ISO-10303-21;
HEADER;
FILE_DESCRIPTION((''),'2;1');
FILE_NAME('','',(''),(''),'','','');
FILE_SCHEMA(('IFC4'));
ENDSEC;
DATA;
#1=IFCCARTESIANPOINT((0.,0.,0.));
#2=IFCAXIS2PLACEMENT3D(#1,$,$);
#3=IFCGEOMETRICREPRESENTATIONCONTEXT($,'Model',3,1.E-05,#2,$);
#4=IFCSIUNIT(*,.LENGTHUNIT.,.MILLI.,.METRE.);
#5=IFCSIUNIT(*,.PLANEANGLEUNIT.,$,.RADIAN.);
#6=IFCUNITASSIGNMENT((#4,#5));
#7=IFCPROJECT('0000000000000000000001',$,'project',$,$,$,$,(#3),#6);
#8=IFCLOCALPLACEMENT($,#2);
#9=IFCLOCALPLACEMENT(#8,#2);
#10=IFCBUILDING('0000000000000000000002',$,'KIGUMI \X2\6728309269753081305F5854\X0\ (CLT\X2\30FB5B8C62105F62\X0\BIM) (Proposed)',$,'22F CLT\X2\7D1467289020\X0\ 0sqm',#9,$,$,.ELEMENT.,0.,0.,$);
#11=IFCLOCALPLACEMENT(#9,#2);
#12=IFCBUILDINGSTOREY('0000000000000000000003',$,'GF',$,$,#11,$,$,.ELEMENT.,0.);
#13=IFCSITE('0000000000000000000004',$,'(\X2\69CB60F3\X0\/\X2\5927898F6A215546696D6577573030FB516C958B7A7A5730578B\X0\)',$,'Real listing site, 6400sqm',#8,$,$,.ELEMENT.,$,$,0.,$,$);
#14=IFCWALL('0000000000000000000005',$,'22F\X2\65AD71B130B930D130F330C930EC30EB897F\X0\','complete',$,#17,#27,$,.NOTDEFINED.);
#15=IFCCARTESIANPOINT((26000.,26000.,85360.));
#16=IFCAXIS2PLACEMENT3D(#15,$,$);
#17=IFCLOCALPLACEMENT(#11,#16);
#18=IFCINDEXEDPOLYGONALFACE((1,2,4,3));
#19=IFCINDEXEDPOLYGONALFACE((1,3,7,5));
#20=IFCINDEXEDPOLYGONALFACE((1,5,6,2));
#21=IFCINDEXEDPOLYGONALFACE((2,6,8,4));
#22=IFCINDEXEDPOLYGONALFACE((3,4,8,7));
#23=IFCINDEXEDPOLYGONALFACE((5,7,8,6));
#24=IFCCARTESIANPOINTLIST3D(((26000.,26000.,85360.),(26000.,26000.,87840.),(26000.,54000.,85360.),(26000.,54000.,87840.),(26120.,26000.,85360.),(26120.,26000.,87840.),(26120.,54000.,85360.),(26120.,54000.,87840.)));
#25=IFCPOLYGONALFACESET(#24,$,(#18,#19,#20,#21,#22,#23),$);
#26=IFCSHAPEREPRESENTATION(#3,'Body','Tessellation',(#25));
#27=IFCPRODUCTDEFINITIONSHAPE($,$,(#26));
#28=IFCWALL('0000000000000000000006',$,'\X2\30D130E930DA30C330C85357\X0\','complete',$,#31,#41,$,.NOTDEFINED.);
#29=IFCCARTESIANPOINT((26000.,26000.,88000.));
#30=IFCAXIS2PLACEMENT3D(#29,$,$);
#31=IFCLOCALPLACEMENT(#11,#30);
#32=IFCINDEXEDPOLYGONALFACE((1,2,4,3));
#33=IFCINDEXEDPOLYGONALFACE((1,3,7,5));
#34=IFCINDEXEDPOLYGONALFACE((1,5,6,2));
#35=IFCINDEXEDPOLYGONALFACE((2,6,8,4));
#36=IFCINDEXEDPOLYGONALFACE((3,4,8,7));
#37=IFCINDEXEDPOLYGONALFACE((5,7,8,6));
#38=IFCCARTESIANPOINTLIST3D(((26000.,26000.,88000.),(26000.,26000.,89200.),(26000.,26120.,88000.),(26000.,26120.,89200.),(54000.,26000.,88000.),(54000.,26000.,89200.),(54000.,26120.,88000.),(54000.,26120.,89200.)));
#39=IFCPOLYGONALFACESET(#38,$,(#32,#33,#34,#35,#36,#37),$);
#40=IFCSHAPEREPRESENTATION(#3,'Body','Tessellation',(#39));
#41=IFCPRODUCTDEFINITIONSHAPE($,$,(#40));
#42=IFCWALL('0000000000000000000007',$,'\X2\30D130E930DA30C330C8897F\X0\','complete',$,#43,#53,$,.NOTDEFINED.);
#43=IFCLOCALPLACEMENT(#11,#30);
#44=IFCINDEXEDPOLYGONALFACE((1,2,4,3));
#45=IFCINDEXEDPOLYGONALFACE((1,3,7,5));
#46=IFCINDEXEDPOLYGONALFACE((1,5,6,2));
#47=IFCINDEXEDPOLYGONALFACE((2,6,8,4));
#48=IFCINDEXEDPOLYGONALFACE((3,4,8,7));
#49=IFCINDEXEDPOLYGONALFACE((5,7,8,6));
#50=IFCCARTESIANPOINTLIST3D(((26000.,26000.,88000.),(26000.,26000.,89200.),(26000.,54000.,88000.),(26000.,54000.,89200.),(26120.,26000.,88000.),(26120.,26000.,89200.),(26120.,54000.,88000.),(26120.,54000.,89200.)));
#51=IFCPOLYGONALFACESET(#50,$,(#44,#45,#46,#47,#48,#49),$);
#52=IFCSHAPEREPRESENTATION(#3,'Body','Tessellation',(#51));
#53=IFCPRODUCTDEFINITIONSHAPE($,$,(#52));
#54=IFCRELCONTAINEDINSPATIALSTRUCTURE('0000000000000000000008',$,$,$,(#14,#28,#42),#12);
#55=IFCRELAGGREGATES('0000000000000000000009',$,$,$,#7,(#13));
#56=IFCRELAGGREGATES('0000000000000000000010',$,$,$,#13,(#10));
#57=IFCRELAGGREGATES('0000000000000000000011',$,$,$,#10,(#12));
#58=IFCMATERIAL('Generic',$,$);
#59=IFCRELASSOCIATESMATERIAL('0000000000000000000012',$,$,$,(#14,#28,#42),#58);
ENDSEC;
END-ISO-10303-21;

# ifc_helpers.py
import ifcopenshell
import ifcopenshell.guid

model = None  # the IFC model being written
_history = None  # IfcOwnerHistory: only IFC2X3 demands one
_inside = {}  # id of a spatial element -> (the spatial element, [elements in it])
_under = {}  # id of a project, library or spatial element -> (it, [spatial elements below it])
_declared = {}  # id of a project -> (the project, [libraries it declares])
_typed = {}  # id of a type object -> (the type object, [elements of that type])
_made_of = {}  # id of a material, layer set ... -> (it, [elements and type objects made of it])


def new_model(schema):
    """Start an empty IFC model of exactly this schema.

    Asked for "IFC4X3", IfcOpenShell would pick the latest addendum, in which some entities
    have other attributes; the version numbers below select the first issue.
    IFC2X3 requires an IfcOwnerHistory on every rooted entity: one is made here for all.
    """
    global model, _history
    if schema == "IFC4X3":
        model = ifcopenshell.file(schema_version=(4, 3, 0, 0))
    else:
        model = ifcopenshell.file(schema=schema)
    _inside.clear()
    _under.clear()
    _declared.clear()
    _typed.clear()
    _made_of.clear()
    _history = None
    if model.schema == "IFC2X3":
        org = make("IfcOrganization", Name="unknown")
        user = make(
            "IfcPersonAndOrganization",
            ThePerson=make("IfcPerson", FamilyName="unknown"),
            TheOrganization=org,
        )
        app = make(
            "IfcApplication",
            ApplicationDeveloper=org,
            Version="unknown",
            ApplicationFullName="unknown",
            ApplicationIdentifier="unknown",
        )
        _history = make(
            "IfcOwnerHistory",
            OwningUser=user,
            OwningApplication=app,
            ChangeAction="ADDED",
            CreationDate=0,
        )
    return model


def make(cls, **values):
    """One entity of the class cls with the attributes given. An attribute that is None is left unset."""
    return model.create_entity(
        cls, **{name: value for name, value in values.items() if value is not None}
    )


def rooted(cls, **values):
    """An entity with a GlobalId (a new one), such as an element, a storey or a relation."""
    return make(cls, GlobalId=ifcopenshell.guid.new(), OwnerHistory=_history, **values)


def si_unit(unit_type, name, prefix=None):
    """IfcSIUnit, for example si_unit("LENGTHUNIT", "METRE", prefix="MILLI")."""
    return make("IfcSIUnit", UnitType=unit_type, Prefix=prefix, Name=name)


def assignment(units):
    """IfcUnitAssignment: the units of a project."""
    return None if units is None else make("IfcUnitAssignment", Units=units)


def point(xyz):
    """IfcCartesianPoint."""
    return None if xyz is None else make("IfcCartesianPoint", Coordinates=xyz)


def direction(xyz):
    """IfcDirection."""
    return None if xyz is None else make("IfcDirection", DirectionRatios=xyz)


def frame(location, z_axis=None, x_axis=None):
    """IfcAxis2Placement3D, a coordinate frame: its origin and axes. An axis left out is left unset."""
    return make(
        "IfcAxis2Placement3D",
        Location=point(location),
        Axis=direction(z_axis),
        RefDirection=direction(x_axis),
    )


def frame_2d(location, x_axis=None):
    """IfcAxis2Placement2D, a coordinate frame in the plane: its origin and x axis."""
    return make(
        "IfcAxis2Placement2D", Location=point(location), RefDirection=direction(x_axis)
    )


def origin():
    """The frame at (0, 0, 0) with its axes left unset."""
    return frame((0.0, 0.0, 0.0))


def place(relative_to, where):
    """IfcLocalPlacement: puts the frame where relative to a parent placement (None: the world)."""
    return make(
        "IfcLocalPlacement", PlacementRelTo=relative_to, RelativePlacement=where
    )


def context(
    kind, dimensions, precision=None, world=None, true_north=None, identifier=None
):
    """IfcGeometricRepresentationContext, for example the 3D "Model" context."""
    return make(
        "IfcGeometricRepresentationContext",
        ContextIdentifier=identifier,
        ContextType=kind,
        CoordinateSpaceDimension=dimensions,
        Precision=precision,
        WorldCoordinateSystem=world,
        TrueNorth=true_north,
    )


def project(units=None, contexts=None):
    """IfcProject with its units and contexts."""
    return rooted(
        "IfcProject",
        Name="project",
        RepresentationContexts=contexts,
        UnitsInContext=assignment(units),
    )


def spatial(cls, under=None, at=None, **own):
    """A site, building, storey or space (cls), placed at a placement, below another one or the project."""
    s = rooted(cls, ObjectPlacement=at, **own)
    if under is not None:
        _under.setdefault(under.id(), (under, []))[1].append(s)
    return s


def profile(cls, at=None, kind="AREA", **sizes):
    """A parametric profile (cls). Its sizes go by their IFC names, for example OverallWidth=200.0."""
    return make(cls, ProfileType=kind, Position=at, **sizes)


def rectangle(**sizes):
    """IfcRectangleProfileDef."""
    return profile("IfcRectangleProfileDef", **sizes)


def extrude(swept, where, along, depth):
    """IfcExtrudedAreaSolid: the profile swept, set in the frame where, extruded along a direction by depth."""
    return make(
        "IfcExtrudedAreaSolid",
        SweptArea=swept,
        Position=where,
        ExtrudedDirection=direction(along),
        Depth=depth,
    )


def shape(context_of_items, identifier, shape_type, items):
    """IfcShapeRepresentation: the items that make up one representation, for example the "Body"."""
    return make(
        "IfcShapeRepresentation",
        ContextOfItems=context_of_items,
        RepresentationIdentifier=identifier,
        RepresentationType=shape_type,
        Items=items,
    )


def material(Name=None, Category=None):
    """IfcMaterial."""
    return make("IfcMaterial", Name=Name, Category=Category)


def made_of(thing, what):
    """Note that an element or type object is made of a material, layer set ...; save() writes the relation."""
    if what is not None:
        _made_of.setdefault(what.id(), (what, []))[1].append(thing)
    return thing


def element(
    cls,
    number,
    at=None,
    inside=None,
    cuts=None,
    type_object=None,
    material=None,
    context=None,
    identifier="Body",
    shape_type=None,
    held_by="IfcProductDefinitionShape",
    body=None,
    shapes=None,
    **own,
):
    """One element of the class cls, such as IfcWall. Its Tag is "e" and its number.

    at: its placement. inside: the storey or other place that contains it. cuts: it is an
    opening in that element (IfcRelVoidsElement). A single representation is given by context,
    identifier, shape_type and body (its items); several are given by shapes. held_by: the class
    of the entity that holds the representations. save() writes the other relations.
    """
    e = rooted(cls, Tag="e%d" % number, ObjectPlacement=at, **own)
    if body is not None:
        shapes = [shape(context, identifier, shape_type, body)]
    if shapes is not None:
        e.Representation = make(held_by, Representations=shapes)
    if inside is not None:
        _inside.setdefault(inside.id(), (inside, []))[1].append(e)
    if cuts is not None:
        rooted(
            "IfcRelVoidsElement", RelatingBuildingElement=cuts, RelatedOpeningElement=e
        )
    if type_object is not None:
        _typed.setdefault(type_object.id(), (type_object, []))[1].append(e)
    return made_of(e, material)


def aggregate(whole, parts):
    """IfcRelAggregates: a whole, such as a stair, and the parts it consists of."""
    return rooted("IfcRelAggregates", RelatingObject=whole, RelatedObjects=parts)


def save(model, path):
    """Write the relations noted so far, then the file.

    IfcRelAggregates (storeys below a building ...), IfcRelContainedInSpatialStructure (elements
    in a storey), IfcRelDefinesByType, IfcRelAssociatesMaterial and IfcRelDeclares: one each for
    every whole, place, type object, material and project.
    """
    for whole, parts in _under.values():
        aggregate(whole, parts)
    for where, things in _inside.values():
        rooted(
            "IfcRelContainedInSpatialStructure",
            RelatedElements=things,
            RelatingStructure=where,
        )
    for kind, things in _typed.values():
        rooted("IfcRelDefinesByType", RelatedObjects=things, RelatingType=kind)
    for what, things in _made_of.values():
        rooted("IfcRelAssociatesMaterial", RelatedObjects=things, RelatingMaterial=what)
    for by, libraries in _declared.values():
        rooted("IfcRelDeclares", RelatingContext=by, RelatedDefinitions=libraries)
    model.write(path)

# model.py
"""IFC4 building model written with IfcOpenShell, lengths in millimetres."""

from ifc_helpers import new_model, si_unit, frame, frame_2d, origin, place, context, project, spatial, rectangle, extrude, material, element, save


model = new_model("IFC4")

# Units and contexts
model_context = context("Model", 3, precision=1e-05, world=origin())
ifc_project = project(units=[si_unit("LENGTHUNIT", "METRE", prefix="MILLI"), si_unit("PLANEANGLEUNIT", "RADIAN")], contexts=[model_context])

# Site, building, storey
site_placement = place(None, origin())
site = spatial("IfcSite", under=ifc_project, at=site_placement, Name="(構想/大規模商業敷地・公開空地型)", ObjectType="Real listing site, 6400sqm", CompositionType="ELEMENT", RefElevation=0.0)
building_placement = place(site_placement, origin())
building = spatial("IfcBuilding", under=site, at=building_placement, Name="KIGUMI 木を極めた塔 (CLT・完成形BIM) (Proposed)", ObjectType="22F CLT純木造 0sqm", CompositionType="ELEMENT", ElevationOfRefHeight=0.0, ElevationOfTerrain=0.0)
storey_placement = place(building_placement, origin())
storey = spatial("IfcBuildingStorey", under=building, at=storey_placement, Name="GF", CompositionType="ELEMENT", Elevation=0.0)

# Shared definitions
ifc_material = material(Name="Generic")

# Walls
wall_1_placement = place(storey_placement, frame((26000.0, 26000.0, 85360.0)))
element("IfcWall", 1, at=wall_1_placement, inside=storey, material=ifc_material, Name="22F断熱スパンドレル西", Description="complete", PredefinedType="NOTDEFINED", context=model_context, shape_type="SweptSolid", body=[
    extrude(rectangle(XDim=120.0, YDim=28000.0, at=frame_2d((60.0, 14000.0))), frame((26000.0, 26000.0, 85360.0)), (0.0, 0.0, 1.0), 2480.0),
])
wall_2_placement = place(storey_placement, frame((26000.0, 26000.0, 88000.0)))
element("IfcWall", 2, at=wall_2_placement, inside=storey, material=ifc_material, Name="パラペット南", Description="complete", PredefinedType="NOTDEFINED", context=model_context, shape_type="SweptSolid", body=[
    extrude(rectangle(XDim=28000.0, YDim=120.0, at=frame_2d((14000.0, 60.0))), frame((26000.0, 26000.0, 88000.0)), (0.0, 0.0, 1.0), 1200.0),
])
wall_3_placement = place(storey_placement, frame((26000.0, 26000.0, 88000.0)))
element("IfcWall", 3, at=wall_3_placement, inside=storey, material=ifc_material, Name="パラペット西", Description="complete", PredefinedType="NOTDEFINED", context=model_context, shape_type="SweptSolid", body=[
    extrude(rectangle(XDim=120.0, YDim=28000.0, at=frame_2d((60.0, 14000.0))), frame((26000.0, 26000.0, 88000.0)), (0.0, 0.0, 1.0), 1200.0),
])

save(model, "model.ifc")
